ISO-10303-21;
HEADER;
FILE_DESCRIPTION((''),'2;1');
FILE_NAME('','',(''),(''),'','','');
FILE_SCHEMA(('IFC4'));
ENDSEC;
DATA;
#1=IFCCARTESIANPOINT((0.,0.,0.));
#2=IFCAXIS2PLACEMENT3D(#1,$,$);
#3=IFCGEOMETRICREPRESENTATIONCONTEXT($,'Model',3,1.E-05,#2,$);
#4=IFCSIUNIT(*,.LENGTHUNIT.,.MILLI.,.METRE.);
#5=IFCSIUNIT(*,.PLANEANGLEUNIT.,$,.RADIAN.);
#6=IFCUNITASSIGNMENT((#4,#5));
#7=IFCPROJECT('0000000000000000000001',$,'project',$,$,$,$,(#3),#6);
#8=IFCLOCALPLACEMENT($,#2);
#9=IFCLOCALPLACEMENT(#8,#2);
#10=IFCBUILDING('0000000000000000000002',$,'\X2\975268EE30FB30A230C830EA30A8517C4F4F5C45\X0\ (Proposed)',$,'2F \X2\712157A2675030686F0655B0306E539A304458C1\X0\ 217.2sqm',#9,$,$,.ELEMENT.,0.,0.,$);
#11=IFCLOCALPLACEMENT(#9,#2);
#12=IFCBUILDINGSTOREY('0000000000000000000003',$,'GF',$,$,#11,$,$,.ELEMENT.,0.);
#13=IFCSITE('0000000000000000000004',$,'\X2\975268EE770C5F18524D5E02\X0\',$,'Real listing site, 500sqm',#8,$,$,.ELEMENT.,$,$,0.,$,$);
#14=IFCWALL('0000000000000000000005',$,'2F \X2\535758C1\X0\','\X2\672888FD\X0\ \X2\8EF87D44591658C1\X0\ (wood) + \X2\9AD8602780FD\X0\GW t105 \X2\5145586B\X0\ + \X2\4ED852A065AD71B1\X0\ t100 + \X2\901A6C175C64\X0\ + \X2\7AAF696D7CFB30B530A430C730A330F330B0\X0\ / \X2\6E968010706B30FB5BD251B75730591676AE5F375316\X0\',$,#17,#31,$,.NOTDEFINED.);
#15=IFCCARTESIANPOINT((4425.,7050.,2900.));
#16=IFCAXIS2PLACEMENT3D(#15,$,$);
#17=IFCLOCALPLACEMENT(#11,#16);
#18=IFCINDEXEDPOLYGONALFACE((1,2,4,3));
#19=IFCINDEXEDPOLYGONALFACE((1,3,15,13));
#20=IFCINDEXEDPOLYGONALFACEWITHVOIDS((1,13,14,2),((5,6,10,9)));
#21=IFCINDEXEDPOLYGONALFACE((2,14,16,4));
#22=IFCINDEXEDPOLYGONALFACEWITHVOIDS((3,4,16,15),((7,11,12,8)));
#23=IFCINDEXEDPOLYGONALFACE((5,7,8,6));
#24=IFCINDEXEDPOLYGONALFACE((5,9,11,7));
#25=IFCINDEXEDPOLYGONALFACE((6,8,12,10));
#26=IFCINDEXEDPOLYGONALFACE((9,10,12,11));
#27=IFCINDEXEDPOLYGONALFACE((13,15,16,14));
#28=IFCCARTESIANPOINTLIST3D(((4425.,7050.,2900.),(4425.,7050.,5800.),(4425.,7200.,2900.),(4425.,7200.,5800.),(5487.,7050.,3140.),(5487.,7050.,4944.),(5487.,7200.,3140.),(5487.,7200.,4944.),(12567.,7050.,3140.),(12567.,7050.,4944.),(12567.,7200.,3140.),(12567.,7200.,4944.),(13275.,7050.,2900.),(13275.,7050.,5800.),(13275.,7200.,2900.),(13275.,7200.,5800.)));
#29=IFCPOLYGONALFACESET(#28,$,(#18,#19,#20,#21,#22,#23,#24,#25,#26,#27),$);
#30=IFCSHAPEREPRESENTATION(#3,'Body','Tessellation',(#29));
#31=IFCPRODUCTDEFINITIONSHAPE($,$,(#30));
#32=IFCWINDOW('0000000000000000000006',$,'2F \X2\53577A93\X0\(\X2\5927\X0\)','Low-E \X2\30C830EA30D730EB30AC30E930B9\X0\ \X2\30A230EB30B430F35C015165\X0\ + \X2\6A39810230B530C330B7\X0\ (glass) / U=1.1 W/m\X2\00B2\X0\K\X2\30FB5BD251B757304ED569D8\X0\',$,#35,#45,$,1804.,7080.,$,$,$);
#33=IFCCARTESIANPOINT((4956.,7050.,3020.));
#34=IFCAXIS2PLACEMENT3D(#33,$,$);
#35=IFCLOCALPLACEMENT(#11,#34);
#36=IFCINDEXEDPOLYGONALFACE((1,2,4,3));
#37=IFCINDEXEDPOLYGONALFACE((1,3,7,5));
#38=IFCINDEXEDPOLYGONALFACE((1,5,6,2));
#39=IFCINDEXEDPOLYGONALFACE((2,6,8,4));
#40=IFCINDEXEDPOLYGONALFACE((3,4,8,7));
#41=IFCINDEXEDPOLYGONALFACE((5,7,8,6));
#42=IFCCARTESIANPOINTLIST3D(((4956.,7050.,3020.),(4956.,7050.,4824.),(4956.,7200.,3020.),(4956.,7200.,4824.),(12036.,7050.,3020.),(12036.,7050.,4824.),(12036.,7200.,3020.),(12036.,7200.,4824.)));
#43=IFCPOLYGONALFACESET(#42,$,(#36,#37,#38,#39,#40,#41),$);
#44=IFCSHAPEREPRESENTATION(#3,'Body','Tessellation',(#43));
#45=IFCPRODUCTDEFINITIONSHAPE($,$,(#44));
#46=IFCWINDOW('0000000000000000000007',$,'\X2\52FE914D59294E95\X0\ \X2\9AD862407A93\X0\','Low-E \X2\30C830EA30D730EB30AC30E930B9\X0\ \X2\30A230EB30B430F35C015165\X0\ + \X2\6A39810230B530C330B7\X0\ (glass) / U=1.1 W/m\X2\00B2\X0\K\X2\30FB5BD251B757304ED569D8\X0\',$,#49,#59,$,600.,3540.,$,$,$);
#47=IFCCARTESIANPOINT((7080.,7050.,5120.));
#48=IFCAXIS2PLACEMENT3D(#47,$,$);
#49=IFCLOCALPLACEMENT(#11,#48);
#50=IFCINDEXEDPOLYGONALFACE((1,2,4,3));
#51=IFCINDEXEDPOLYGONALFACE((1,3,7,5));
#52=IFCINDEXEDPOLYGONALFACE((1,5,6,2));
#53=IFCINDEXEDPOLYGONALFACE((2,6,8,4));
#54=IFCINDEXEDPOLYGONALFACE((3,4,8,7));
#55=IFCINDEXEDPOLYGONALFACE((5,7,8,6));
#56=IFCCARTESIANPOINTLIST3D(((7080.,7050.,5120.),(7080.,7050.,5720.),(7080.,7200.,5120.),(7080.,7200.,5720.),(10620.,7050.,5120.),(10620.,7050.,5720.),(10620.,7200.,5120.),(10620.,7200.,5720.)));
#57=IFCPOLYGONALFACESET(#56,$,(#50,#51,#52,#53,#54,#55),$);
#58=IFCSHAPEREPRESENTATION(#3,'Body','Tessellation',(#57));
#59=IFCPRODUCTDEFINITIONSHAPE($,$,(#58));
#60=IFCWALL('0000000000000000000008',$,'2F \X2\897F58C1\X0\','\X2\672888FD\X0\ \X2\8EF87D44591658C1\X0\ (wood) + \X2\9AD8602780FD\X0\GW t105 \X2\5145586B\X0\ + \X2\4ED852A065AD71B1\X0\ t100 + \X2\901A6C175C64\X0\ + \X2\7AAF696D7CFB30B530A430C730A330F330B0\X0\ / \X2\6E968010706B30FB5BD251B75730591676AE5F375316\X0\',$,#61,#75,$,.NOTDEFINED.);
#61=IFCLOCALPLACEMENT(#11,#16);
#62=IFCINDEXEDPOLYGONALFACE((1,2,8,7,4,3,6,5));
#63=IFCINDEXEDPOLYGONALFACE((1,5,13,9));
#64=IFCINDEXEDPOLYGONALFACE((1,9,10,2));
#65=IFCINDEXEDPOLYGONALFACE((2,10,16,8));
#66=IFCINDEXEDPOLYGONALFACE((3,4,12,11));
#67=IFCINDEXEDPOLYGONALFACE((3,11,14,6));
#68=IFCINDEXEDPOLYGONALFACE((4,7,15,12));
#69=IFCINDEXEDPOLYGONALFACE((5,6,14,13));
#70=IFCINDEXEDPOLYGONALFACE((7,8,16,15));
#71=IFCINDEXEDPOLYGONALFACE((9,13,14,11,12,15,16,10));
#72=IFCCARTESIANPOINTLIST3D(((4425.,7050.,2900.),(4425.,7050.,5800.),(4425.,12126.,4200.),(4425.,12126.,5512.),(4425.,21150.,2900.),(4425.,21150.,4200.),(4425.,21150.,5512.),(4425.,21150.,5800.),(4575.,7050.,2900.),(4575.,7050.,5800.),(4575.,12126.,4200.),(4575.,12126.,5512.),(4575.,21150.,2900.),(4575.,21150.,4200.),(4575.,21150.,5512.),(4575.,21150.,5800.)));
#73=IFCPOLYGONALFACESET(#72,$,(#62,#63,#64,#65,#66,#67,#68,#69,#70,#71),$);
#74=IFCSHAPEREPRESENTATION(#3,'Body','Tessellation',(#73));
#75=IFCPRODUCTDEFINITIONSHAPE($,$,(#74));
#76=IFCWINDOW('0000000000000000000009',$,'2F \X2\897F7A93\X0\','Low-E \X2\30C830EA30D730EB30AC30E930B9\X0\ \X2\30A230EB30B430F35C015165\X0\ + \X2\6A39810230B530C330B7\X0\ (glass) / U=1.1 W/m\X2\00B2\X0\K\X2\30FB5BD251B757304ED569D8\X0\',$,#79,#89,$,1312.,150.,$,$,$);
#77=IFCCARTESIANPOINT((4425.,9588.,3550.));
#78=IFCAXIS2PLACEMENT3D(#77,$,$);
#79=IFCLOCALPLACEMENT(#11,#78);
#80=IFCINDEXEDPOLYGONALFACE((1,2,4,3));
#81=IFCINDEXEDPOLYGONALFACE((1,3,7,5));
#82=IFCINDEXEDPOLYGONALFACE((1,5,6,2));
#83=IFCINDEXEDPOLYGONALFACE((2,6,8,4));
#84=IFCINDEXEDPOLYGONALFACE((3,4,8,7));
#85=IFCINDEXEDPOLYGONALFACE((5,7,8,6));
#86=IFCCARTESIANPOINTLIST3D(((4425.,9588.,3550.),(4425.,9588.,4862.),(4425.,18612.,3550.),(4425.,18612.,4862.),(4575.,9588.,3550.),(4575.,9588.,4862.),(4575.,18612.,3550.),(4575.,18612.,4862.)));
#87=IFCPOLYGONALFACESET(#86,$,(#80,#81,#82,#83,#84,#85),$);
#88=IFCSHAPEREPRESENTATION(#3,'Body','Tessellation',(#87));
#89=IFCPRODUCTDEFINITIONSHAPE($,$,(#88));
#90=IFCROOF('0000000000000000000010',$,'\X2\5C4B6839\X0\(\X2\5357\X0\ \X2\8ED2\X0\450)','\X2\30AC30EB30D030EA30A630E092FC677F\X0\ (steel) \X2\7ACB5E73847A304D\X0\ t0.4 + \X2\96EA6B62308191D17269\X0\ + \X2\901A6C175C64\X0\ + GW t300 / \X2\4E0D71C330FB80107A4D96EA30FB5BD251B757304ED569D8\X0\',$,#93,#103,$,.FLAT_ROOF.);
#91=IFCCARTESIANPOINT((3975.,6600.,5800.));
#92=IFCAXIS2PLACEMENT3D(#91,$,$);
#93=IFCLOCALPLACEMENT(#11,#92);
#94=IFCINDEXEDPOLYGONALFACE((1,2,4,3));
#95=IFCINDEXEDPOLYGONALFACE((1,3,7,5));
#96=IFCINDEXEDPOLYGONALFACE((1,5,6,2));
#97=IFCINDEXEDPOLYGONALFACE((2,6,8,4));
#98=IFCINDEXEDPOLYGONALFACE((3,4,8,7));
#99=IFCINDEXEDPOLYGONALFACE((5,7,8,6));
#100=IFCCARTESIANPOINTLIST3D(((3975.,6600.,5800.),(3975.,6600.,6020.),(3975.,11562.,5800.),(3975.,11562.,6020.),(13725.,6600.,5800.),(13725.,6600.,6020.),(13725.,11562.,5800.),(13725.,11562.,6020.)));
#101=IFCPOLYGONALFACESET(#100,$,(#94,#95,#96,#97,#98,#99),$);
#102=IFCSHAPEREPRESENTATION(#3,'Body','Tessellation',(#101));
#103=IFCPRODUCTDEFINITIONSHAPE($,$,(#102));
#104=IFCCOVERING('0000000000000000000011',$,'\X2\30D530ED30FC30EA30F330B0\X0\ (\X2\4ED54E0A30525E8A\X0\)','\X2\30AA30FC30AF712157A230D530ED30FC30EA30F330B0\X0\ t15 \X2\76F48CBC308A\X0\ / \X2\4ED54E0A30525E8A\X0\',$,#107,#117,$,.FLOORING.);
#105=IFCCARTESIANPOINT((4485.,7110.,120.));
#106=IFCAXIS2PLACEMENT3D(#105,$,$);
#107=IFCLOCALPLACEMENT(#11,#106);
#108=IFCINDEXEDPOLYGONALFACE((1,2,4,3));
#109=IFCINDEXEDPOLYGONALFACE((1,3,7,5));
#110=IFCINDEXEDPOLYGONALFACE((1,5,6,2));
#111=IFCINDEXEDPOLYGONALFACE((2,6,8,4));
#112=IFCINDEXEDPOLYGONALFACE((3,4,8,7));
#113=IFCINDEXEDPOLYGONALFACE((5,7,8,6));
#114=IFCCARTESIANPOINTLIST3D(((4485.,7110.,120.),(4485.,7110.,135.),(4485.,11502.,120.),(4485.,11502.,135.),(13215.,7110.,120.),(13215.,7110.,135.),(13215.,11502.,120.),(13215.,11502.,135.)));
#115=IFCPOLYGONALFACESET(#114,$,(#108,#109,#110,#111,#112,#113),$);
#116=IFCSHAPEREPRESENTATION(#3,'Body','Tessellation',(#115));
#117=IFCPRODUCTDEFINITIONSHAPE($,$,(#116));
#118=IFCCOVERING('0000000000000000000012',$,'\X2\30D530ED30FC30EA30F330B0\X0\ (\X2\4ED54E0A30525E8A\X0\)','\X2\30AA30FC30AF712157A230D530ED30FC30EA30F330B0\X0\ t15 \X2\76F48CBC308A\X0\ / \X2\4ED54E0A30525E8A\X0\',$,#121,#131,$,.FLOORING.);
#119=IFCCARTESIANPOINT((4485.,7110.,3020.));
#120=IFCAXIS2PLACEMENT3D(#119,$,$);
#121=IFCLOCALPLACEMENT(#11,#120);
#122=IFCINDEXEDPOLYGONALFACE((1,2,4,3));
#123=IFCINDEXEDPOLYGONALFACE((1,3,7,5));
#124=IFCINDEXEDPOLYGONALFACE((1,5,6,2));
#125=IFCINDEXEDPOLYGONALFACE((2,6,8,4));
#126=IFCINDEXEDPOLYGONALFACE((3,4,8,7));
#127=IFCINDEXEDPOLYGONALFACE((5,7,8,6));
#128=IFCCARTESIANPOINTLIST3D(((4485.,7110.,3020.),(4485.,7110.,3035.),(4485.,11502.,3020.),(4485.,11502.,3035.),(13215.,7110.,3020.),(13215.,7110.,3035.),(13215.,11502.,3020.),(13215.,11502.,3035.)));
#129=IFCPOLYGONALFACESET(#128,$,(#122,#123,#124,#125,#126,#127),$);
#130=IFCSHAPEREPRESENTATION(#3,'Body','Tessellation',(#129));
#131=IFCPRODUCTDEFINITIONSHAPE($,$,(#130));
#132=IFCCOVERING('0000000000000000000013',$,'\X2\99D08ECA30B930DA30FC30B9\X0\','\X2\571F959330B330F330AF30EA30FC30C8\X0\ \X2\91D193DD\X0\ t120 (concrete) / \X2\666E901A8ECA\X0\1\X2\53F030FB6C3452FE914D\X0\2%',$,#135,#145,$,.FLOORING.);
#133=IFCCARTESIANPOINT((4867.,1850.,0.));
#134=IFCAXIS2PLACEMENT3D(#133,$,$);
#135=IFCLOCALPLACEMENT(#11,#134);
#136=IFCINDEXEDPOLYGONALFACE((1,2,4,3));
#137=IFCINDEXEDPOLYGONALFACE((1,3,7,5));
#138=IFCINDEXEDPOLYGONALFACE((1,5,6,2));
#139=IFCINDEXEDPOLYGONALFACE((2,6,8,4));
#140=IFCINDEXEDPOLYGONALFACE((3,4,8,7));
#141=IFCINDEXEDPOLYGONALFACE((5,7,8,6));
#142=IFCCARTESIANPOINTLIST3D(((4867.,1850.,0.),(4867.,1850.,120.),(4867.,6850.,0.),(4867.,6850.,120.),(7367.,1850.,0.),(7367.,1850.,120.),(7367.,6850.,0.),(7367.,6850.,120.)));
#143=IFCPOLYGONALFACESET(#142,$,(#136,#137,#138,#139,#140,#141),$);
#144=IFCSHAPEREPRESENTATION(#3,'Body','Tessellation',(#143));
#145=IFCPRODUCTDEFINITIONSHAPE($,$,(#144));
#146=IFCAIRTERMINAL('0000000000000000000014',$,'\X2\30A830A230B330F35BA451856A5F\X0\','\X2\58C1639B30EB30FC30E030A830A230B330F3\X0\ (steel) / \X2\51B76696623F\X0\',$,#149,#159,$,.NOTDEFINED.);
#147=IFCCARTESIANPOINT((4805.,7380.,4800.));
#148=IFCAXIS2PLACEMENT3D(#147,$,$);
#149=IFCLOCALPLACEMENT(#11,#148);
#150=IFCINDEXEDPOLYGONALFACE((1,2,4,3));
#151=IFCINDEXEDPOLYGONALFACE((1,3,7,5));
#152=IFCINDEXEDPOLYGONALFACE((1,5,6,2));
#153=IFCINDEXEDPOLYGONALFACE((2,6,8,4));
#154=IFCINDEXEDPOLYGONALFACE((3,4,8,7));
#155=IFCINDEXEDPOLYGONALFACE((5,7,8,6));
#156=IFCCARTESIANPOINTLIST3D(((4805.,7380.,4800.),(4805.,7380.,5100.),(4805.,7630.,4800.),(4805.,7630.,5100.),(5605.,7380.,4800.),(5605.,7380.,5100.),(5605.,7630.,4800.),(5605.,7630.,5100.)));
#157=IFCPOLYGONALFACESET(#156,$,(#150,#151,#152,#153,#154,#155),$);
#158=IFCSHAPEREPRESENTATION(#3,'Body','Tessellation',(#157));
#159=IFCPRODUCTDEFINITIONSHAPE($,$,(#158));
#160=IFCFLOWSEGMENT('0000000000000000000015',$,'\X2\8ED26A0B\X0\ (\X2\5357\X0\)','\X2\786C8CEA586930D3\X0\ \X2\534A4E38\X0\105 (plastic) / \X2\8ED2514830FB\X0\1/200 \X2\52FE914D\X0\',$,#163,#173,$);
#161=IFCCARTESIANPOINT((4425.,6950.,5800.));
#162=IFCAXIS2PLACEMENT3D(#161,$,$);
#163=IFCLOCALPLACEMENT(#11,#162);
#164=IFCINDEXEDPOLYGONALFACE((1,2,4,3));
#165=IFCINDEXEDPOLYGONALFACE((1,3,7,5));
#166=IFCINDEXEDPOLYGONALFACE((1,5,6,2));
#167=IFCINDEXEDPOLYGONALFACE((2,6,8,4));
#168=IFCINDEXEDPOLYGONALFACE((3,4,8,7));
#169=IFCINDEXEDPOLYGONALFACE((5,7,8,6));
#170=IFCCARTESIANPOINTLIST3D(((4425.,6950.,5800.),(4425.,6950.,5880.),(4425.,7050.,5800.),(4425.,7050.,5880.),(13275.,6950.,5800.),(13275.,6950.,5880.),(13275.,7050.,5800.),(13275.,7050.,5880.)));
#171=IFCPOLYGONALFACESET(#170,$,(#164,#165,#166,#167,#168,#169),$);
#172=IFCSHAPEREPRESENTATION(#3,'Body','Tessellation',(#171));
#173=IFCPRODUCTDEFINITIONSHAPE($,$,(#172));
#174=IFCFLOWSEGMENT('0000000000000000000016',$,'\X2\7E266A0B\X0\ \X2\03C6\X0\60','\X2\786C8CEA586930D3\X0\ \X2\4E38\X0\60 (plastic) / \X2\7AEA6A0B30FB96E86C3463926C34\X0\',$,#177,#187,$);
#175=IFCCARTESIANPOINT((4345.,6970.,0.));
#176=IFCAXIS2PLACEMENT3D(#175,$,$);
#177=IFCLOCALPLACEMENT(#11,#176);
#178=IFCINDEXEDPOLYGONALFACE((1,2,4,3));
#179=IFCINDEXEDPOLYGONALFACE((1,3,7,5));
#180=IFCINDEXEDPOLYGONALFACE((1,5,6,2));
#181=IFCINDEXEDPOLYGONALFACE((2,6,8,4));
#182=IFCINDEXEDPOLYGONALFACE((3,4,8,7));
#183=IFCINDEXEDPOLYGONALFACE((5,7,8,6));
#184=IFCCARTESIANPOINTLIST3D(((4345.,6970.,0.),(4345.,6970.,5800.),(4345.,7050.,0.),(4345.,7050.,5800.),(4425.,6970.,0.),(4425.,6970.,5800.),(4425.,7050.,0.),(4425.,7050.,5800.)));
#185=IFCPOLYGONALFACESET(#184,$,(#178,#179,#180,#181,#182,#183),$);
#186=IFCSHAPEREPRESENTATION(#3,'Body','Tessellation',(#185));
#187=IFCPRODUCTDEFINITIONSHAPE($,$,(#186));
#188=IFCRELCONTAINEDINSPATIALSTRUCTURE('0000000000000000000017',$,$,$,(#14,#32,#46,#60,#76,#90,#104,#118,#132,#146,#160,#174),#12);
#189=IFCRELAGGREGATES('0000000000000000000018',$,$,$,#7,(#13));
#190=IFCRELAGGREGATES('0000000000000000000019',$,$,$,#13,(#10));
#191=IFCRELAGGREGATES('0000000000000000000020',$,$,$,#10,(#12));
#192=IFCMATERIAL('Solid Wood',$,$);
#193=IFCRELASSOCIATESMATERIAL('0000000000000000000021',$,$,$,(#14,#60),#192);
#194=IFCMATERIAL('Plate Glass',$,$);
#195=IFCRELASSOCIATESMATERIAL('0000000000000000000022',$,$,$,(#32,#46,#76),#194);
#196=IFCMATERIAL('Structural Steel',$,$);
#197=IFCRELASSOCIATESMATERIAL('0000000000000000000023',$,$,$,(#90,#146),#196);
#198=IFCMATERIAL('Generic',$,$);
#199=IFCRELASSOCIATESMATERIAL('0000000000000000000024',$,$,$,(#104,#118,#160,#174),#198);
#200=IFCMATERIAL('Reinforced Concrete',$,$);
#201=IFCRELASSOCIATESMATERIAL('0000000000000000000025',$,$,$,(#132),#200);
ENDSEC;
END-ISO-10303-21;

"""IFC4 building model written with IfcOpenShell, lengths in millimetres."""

from ifc_helpers import new_model, si_unit, frame, frame_2d, origin, place, context, project, spatial, rectangle, extrude, material, element, fill, save


model = new_model("IFC4")

# Units and contexts
model_context = context("Model", 3, precision=1e-05, world=origin())
ifc_project = project(units=[si_unit("LENGTHUNIT", "METRE", prefix="MILLI"), si_unit("PLANEANGLEUNIT", "RADIAN")], contexts=[model_context])

# Site, building, storey
site_placement = place(None, origin())
site = spatial("IfcSite", under=ifc_project, at=site_placement, Name="青森県弘前市", ObjectType="Real listing site, 500sqm", CompositionType="ELEMENT", RefElevation=0.0)
building_placement = place(site_placement, origin())
building = spatial("IfcBuilding", under=site, at=building_placement, Name="青森・アトリエ兼住居 (Proposed)", ObjectType="2F 無垢材と漆喰の厚い壁 217.2sqm", CompositionType="ELEMENT", ElevationOfRefHeight=0.0, ElevationOfTerrain=0.0)
storey_placement = place(building_placement, origin())
storey = spatial("IfcBuildingStorey", under=building, at=storey_placement, Name="GF", CompositionType="ELEMENT", Elevation=0.0)

# Shared definitions
ifc_material_1 = material(Name="Solid Wood")

# Shared definitions
ifc_material_2 = material(Name="Reinforced Concrete")

# Shared definitions
ifc_material_3 = material(Name="Plate Glass")

# Wall, openings, windows
wall_1_placement = place(storey_placement, frame((4425.0, 7050.0, 2900.0)))
wall_1 = element("IfcWall", 1, at=wall_1_placement, inside=storey, material=ifc_material_1, Name="2F 南壁", Description="木製 軸組外壁 (wood) + 高性能GW t105 充填 + 付加断熱 t100 + 通気層 + 窯業系サイディング / 準耐火・寒冷地外皮強化", PredefinedType="NOTDEFINED", context=model_context, shape_type="SweptSolid", body=[
    extrude(rectangle(XDim=8850.0, YDim=150.0, at=frame_2d((4425.0, 75.0))), frame((4425.0, 7050.0, 2900.0)), (0.0, 0.0, 1.0), 2900.0),
])
opening_1_placement = place(storey_placement, frame((4956.0, 7050.0, 3020.0)))
opening_1 = element("IfcOpeningElement", 2, at=opening_1_placement, cuts=wall_1, PredefinedType="NOTDEFINED", context=model_context, shape_type="SweptSolid", body=[
    extrude(rectangle(XDim=7080.0, YDim=150.0, at=frame_2d((3540.0, 75.0))), frame((4956.0, 7050.0, 3020.0)), (0.0, 0.0, 1.0), 1804.0),
])
opening_2_placement = place(storey_placement, frame((7080.0, 7050.0, 5120.0)))
opening_2 = element("IfcOpeningElement", 3, at=opening_2_placement, cuts=wall_1, PredefinedType="NOTDEFINED", context=model_context, shape_type="SweptSolid", body=[
    extrude(rectangle(XDim=3540.0, YDim=150.0, at=frame_2d((1770.0, 75.0))), frame((7080.0, 7050.0, 5120.0)), (0.0, 0.0, 1.0), 600.0),
])
window_1_placement = place(storey_placement, frame((4956.0, 7050.0, 3020.0)))
window_1 = element("IfcWindow", 4, at=window_1_placement, inside=storey, material=ifc_material_3, Name="2F 南窓(大)", Description="Low-E トリプルガラス アルゴン封入 + 樹脂サッシ (glass) / U=1.1 W/m²K・寒冷地仕様", OverallHeight=1804.0, OverallWidth=7080.0, context=model_context, shape_type="SweptSolid", body=[
    extrude(rectangle(XDim=7080.0, YDim=150.0, at=frame_2d((3540.0, 75.0))), frame((4956.0, 7050.0, 3020.0)), (0.0, 0.0, 1.0), 1804.0),
])
fill(opening_1, window_1)
window_2_placement = place(storey_placement, frame((7080.0, 7050.0, 5120.0)))
window_2 = element("IfcWindow", 5, at=window_2_placement, inside=storey, material=ifc_material_3, Name="勾配天井 高所窓", Description="Low-E トリプルガラス アルゴン封入 + 樹脂サッシ (glass) / U=1.1 W/m²K・寒冷地仕様", OverallHeight=600.0, OverallWidth=3540.0, context=model_context, shape_type="SweptSolid", body=[
    extrude(rectangle(XDim=3540.0, YDim=150.0, at=frame_2d((1770.0, 75.0))), frame((7080.0, 7050.0, 5120.0)), (0.0, 0.0, 1.0), 600.0),
])
fill(opening_2, window_2)

# Wall, opening, window
wall_2_placement = place(storey_placement, frame((4425.0, 7050.0, 2900.0)))
wall_2 = element("IfcWall", 6, at=wall_2_placement, inside=storey, material=ifc_material_1, Name="2F 西壁", Description="木製 軸組外壁 (wood) + 高性能GW t105 充填 + 付加断熱 t100 + 通気層 + 窯業系サイディング / 準耐火・寒冷地外皮強化", PredefinedType="NOTDEFINED", context=model_context, shape_type="SweptSolid", body=[
    extrude(rectangle(XDim=150.0, YDim=14100.0, at=frame_2d((75.0, 7050.0))), frame((4425.0, 7050.0, 2900.0)), (0.0, 0.0, 1.0), 2900.0),
])
opening_3_placement = place(storey_placement, frame((4425.0, 9588.0, 3550.0)))
opening_3 = element("IfcOpeningElement", 7, at=opening_3_placement, cuts=wall_2, PredefinedType="NOTDEFINED", context=model_context, shape_type="SweptSolid", body=[
    extrude(rectangle(XDim=150.0, YDim=9024.0, at=frame_2d((75.0, 4512.0))), frame((4425.0, 9588.0, 3550.0)), (0.0, 0.0, 1.0), 1312.0),
])
window_3_placement = place(storey_placement, frame((4425.0, 9588.0, 3550.0)))
window_3 = element("IfcWindow", 8, at=window_3_placement, inside=storey, material=ifc_material_3, Name="2F 西窓", Description="Low-E トリプルガラス アルゴン封入 + 樹脂サッシ (glass) / U=1.1 W/m²K・寒冷地仕様", OverallHeight=1312.0, OverallWidth=150.0, context=model_context, shape_type="SweptSolid", body=[
    extrude(rectangle(XDim=150.0, YDim=9024.0, at=frame_2d((75.0, 4512.0))), frame((4425.0, 9588.0, 3550.0)), (0.0, 0.0, 1.0), 1312.0),
])
fill(opening_3, window_3)

# Roof
ifc_material_4 = material(Name="Structural Steel")
for number, where, name in (
    (9, (3975.0, 6600.0, 5800.0), "屋根(南 軒450)"),
):
    element("IfcRoof", number, at=place(storey_placement, frame(where)), inside=storey, material=ifc_material_4, Name=name, Description="ガルバリウム鋼板 (steel) 立平葺き t0.4 + 雪止め金物 + 通気層 + GW t300 / 不燃・耐積雪・寒冷地仕様", PredefinedType="FLAT_ROOF", context=model_context, shape_type="SweptSolid", body=[
        extrude(rectangle(XDim=9750.0, YDim=4962.0, at=frame_2d((4875.0, 2481.0))), frame((3975.0, 6600.0, 5800.0)), (0.0, 0.0, 1.0), 220.0),
    ])

# Coverings
ifc_material_5 = material(Name="Generic")
covering_1_placement = place(storey_placement, frame((4485.0, 7110.0, 120.0)))
element("IfcCovering", 10, at=covering_1_placement, inside=storey, material=ifc_material_5, Name="フローリング (仕上げ床)", Description="オーク無垢フローリング t15 直貼り / 仕上げ床", PredefinedType="FLOORING", context=model_context, shape_type="SweptSolid", body=[
    extrude(rectangle(XDim=8730.0, YDim=4392.0, at=frame_2d((4365.0, 2196.0))), frame((4485.0, 7110.0, 120.0)), (0.0, 0.0, 1.0), 15.0),
])
covering_2_placement = place(storey_placement, frame((4485.0, 7110.0, 3020.0)))
element("IfcCovering", 11, at=covering_2_placement, inside=storey, material=ifc_material_5, Name="フローリング (仕上げ床)", Description="オーク無垢フローリング t15 直貼り / 仕上げ床", PredefinedType="FLOORING", context=model_context, shape_type="SweptSolid", body=[
    extrude(rectangle(XDim=8730.0, YDim=4392.0, at=frame_2d((4365.0, 2196.0))), frame((4485.0, 7110.0, 3020.0)), (0.0, 0.0, 1.0), 15.0),
])
covering_3_placement = place(storey_placement, frame((4867.0, 1850.0, 0.0)))
element("IfcCovering", 12, at=covering_3_placement, inside=storey, material=ifc_material_2, Name="駐車スペース", Description="土間コンクリート 金鏝 t120 (concrete) / 普通車1台・水勾配2%", PredefinedType="FLOORING", context=model_context, shape_type="SweptSolid", body=[
    extrude(rectangle(XDim=2500.0, YDim=5000.0, at=frame_2d((1250.0, 2500.0))), frame((4867.0, 1850.0, 0.0)), (0.0, 0.0, 1.0), 120.0),
])

# Air terminal
air_terminal_placement = place(storey_placement, frame((4805.0, 7380.0, 4800.0)))
element("IfcAirTerminal", 13, at=air_terminal_placement, inside=storey, material=ifc_material_4, Name="エアコン室内機", Description="壁掛ルームエアコン (steel) / 冷暖房", PredefinedType="NOTDEFINED", context=model_context, shape_type="SweptSolid", body=[
    extrude(rectangle(XDim=800.0, YDim=250.0, at=frame_2d((400.0, 125.0))), frame((4805.0, 7380.0, 4800.0)), (0.0, 0.0, 1.0), 300.0),
])

# Flow segments
flow_segment_1_placement = place(storey_placement, frame((4425.0, 6950.0, 5800.0)))
element("IfcFlowSegment", 14, at=flow_segment_1_placement, inside=storey, material=ifc_material_5, Name="軒樋 (南)", Description="硬質塩ビ 半丸105 (plastic) / 軒先・1/200 勾配", context=model_context, shape_type="SweptSolid", body=[
    extrude(rectangle(XDim=8850.0, YDim=100.0, at=frame_2d((4425.0, 50.0))), frame((4425.0, 6950.0, 5800.0)), (0.0, 0.0, 1.0), 80.0),
])
flow_segment_2_placement = place(storey_placement, frame((4345.0, 6970.0, 0.0)))
element("IfcFlowSegment", 15, at=flow_segment_2_placement, inside=storey, material=ifc_material_5, Name="縦樋 φ60", Description="硬質塩ビ 丸60 (plastic) / 竪樋・雨水排水", context=model_context, shape_type="SweptSolid", body=[
    extrude(rectangle(XDim=80.0, YDim=80.0, at=frame_2d((40.0, 40.0))), frame((4345.0, 6970.0, 0.0)), (0.0, 0.0, 1.0), 5800.0),
])

save(model, "model.ifc")
